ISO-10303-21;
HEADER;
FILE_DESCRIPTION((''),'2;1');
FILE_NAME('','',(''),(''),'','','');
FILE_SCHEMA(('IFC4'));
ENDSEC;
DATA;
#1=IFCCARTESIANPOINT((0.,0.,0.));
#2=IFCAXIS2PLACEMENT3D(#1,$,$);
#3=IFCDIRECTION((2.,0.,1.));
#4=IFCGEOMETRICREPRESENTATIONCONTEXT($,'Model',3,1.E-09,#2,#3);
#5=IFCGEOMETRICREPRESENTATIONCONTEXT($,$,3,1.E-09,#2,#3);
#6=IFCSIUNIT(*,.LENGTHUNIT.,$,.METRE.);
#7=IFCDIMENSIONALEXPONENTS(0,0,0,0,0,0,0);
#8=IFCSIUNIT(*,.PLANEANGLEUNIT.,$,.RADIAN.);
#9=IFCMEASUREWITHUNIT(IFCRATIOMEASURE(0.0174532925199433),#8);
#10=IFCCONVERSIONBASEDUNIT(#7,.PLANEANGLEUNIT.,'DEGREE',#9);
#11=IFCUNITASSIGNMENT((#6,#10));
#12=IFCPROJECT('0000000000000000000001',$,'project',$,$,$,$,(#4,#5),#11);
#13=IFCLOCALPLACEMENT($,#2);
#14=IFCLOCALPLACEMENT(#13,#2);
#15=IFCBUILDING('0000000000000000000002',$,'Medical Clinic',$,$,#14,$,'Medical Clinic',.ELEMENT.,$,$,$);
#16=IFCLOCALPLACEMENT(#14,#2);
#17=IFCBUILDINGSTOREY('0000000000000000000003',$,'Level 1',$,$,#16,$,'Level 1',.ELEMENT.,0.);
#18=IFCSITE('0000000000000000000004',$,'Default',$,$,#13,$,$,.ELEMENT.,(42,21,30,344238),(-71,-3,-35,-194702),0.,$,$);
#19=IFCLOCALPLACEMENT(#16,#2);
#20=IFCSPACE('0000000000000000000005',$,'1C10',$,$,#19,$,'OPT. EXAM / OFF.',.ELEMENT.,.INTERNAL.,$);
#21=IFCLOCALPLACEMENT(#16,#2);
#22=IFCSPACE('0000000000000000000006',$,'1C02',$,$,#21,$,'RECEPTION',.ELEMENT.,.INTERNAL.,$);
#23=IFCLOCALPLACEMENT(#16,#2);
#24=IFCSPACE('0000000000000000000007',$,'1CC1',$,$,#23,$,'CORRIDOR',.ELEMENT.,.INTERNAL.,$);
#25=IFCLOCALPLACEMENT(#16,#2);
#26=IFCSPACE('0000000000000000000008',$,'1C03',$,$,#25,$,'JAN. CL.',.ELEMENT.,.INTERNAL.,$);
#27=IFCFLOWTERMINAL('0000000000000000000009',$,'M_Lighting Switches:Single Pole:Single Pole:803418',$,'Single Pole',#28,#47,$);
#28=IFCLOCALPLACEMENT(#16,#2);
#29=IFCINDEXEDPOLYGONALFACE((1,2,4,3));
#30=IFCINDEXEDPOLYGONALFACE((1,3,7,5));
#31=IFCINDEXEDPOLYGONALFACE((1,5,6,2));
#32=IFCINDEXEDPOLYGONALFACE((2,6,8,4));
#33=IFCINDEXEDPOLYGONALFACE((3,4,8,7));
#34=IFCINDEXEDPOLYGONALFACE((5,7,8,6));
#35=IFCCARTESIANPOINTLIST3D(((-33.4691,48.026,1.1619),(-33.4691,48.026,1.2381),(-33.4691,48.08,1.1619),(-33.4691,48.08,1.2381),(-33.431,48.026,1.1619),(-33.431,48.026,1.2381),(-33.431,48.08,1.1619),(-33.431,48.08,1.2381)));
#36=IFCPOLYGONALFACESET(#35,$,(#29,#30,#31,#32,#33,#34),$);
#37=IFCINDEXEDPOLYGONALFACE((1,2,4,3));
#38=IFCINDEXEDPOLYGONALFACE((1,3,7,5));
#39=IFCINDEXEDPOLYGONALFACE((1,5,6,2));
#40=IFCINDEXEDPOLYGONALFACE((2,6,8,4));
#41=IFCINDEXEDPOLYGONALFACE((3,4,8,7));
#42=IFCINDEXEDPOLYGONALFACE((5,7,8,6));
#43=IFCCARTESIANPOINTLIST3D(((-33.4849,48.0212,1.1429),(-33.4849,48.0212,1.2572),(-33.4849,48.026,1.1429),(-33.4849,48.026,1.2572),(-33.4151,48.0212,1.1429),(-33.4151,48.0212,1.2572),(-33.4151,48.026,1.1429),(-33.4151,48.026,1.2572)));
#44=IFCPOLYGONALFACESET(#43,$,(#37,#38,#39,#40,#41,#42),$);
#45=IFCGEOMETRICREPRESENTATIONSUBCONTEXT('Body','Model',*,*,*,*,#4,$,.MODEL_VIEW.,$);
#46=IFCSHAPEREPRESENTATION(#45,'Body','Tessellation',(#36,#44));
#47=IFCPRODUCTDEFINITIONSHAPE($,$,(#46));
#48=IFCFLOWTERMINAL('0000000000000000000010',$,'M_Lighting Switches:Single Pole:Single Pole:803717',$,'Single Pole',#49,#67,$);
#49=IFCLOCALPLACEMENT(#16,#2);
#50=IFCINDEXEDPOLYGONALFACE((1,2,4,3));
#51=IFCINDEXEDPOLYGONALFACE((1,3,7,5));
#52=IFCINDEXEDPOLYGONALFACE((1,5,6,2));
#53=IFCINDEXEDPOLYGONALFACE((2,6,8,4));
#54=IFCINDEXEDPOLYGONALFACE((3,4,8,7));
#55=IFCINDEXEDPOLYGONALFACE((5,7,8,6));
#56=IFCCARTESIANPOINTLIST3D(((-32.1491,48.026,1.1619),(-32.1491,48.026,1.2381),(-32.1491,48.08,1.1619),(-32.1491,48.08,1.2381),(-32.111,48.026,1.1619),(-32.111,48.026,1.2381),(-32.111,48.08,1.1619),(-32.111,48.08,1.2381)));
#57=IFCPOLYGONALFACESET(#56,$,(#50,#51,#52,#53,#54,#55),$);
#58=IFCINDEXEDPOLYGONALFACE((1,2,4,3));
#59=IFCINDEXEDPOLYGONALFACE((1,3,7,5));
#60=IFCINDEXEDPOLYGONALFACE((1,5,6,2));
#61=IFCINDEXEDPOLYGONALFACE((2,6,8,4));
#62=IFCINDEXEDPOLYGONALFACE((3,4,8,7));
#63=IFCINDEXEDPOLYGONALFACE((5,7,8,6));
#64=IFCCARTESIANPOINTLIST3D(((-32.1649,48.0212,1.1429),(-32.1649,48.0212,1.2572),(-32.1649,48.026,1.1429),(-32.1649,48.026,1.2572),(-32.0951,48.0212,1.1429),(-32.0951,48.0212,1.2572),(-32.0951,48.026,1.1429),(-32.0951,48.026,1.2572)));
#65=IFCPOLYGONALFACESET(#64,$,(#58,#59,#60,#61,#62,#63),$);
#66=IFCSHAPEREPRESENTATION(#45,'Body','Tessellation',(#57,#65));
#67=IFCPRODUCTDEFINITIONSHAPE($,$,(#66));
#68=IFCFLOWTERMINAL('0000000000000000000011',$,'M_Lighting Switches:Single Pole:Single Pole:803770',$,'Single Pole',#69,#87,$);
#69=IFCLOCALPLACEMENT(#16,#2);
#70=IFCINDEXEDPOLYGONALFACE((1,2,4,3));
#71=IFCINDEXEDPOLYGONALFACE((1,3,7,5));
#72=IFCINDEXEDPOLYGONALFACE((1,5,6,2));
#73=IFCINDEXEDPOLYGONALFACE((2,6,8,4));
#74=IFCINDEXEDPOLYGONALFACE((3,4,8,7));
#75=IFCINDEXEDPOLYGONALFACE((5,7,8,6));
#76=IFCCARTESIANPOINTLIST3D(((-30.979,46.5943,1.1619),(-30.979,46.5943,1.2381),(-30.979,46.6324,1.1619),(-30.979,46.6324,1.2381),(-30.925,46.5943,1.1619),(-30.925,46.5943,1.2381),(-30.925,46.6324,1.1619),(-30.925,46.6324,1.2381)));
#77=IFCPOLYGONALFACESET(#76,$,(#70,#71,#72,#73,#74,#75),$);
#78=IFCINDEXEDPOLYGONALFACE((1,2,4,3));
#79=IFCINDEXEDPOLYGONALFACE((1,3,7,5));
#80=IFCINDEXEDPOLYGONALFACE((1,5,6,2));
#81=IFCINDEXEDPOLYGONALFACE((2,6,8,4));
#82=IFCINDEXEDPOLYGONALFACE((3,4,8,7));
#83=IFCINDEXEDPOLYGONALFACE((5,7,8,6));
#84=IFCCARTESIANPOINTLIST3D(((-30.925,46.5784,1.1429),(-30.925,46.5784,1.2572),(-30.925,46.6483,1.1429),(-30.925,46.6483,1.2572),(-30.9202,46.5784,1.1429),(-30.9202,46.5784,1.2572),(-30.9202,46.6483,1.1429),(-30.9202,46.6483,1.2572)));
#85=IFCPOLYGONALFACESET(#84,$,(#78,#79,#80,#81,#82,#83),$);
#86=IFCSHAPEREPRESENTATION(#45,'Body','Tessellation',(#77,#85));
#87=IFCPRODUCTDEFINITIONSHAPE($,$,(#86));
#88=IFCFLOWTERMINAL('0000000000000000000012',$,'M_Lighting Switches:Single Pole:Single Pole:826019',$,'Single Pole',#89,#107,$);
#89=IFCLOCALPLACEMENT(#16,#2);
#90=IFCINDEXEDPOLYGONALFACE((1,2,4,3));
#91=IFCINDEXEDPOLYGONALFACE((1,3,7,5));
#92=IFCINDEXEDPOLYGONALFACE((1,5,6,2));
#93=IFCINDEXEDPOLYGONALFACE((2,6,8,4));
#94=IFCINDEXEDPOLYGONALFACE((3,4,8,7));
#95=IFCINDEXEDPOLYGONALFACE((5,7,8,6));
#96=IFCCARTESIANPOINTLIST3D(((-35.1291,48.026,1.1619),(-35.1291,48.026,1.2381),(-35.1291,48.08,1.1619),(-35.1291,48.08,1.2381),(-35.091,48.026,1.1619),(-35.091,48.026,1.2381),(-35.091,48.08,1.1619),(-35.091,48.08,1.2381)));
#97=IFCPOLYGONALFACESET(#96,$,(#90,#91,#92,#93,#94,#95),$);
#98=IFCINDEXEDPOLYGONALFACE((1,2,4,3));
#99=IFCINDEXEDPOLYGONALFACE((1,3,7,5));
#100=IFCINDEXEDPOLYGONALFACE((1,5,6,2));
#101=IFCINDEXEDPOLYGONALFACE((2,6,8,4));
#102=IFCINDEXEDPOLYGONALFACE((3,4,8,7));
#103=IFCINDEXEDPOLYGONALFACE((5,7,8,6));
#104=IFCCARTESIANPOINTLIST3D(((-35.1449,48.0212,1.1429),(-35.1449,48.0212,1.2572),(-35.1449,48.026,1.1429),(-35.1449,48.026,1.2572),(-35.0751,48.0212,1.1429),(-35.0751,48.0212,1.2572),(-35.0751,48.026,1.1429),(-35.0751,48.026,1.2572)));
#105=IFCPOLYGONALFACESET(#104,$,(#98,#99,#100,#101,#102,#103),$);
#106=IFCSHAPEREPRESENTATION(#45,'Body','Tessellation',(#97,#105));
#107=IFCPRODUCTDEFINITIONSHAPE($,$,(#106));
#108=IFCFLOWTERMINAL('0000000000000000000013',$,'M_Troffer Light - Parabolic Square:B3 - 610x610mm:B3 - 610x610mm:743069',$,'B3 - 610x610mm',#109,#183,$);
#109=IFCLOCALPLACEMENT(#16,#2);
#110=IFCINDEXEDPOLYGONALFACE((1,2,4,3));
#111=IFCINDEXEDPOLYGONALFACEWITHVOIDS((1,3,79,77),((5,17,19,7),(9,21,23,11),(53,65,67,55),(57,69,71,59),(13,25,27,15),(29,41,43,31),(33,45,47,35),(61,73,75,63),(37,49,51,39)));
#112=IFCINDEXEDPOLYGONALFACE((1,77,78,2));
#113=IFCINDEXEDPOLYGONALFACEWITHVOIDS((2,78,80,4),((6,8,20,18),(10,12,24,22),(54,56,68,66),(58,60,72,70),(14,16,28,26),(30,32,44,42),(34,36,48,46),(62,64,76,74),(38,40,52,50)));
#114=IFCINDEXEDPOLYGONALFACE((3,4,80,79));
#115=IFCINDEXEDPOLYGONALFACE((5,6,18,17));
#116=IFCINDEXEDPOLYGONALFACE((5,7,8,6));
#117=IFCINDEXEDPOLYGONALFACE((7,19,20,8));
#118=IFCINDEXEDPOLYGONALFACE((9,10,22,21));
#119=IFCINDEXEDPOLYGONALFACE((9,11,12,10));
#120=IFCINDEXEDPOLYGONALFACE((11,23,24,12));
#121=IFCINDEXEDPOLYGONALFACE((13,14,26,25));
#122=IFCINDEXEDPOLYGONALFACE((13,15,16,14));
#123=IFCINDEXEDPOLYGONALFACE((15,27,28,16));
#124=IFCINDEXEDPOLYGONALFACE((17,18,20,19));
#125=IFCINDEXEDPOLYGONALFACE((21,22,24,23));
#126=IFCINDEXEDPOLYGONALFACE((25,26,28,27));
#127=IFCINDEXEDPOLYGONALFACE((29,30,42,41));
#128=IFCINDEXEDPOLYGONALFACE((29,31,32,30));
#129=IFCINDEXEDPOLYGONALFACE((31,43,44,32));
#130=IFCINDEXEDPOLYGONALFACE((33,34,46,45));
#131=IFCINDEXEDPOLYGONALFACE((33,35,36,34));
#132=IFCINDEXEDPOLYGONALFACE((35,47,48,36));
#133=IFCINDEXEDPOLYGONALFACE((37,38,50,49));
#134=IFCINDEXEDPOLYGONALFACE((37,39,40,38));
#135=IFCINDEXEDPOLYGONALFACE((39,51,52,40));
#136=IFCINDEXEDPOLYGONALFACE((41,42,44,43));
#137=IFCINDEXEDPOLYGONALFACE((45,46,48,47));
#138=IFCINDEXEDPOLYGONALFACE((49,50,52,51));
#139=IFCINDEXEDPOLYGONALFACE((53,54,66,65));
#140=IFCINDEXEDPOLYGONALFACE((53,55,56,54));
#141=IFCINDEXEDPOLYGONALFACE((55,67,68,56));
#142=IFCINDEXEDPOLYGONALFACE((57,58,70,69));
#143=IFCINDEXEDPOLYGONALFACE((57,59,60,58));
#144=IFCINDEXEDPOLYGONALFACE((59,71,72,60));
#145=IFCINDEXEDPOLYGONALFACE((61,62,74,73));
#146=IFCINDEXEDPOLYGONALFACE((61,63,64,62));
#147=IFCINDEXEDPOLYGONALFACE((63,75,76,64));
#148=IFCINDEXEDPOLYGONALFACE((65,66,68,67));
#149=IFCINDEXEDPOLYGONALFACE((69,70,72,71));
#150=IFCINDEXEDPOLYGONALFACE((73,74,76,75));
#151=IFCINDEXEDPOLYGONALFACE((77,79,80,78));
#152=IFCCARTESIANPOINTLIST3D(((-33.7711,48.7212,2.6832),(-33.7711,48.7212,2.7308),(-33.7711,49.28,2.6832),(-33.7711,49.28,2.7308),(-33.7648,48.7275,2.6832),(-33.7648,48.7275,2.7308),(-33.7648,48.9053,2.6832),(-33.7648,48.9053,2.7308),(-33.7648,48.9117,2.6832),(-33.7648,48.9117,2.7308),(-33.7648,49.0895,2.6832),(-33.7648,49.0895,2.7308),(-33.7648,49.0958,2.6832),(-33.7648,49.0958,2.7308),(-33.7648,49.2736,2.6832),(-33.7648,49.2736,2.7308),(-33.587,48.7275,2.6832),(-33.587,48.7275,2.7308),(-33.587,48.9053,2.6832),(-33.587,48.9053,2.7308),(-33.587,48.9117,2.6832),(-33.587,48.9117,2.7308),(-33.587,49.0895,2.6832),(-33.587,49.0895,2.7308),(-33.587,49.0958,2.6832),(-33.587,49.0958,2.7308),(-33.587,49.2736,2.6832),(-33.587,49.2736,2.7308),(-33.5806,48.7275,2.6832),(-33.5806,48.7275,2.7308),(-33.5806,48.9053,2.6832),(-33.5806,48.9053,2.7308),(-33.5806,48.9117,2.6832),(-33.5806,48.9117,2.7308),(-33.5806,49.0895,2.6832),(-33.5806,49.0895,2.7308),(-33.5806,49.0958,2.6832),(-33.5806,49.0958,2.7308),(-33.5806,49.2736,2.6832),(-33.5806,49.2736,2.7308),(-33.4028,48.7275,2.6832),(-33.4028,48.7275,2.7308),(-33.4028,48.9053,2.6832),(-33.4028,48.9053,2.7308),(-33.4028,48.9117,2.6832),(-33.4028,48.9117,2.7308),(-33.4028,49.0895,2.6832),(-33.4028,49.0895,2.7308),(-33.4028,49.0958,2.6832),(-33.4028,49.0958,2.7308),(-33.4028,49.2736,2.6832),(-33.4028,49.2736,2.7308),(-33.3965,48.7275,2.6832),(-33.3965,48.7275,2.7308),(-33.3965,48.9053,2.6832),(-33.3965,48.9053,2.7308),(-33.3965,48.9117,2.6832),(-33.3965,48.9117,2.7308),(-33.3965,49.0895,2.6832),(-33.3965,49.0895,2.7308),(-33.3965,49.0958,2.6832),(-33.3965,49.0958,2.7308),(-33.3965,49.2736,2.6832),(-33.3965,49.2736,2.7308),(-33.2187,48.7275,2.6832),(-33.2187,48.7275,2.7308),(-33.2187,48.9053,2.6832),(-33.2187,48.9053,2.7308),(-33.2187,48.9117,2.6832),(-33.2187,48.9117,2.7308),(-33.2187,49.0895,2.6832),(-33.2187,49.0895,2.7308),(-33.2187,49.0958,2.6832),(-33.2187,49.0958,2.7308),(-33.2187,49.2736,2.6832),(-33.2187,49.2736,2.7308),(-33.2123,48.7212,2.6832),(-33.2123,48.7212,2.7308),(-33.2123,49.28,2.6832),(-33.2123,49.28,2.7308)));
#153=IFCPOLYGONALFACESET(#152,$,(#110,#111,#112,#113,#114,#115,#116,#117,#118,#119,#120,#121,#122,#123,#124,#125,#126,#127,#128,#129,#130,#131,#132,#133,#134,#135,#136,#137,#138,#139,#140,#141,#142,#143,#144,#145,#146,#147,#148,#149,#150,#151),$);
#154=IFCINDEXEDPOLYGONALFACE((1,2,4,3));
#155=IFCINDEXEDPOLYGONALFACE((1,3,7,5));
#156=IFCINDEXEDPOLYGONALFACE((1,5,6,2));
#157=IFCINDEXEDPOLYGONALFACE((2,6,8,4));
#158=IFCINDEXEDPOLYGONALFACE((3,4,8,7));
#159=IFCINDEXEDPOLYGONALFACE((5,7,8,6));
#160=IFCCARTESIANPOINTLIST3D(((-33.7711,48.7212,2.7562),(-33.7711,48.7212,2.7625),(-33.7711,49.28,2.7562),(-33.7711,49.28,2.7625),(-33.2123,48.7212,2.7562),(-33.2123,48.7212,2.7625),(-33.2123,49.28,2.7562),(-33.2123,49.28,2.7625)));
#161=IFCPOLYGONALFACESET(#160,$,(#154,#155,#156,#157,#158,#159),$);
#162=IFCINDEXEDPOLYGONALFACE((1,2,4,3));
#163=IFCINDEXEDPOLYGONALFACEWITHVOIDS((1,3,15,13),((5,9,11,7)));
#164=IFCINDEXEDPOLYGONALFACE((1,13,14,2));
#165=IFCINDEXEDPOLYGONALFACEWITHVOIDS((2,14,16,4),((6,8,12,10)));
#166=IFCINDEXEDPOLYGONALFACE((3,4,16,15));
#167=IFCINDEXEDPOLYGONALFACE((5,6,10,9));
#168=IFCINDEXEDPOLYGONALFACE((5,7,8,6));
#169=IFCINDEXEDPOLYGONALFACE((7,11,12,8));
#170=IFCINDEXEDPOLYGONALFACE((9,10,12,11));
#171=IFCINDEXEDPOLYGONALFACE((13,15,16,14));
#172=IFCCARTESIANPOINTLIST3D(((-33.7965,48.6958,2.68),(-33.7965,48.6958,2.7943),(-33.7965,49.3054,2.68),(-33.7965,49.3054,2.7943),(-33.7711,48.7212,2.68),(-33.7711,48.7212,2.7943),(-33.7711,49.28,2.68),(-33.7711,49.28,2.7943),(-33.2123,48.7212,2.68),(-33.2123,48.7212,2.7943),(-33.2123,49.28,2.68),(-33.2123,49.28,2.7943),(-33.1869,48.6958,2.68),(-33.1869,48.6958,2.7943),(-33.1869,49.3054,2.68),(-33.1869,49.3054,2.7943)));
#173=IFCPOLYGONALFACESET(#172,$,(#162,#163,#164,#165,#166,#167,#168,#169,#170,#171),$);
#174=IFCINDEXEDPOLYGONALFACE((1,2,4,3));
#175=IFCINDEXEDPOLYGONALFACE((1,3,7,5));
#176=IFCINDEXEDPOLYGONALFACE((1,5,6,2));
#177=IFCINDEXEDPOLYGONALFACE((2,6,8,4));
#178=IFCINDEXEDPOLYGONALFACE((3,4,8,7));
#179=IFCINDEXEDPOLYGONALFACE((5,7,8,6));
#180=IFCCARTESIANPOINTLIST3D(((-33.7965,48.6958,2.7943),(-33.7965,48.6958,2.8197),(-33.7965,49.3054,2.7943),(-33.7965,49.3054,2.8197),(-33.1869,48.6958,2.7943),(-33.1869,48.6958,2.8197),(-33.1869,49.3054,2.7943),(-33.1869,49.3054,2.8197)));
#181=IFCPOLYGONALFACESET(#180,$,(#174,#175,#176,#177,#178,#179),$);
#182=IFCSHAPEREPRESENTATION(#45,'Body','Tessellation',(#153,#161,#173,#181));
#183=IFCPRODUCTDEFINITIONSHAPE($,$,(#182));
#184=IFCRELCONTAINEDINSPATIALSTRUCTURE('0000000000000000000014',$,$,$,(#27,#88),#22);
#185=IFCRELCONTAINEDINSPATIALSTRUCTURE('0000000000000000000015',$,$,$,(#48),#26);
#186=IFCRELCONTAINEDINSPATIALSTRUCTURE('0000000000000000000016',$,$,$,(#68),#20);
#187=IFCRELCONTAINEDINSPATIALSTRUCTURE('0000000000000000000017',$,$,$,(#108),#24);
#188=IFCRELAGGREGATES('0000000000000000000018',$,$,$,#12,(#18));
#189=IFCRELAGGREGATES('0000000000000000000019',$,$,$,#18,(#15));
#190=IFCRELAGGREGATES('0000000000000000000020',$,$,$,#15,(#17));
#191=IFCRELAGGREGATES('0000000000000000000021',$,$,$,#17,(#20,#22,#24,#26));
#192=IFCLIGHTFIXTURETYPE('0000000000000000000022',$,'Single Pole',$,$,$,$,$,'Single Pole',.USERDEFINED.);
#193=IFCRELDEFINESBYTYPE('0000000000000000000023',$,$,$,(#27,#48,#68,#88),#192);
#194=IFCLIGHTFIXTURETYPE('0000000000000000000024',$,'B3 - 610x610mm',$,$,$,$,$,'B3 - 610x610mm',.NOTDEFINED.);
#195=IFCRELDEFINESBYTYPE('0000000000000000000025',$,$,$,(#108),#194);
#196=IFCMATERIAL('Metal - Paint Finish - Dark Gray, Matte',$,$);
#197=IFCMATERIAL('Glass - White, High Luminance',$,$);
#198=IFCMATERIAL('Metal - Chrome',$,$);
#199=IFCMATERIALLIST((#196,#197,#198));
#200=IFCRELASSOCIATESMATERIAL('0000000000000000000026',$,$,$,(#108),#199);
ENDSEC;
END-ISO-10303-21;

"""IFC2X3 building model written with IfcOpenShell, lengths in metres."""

from ifc_helpers import new_model, entity, si_unit, converted_unit, direction, frame, frame_2d, origin, origin_2d_with_axis, place, context, subcontext, project, spatial, polyline, rectangle, outline, extrude, source, transform, mapped, material, material_list, type_object, type_shapes, element, save


model = new_model("IFC2X3")

# Units and contexts
model_context = context("Model", 3, precision=1e-09, world=origin(), true_north=direction((2.0, 0.0, 1.0)))
context_of_model = context(None, 3, precision=1e-09, world=origin(), true_north=direction((2.0, 0.0, 1.0)))
body_context = subcontext(model_context, "Body", "Model", "MODEL_VIEW")
ifc_project = project(units=[si_unit("LENGTHUNIT", "METRE"), converted_unit("PLANEANGLEUNIT", "DEGREE", entity("IfcRatioMeasure", 0.0174532925199433), si_unit("PLANEANGLEUNIT", "RADIAN"), dimensions=[0, 0, 0, 0, 0, 0, 0])], contexts=[model_context, context_of_model])

# Site, building, storey, space
site_placement = place(None, origin())
site = spatial("IfcSite", under=ifc_project, at=site_placement, Name="Default", CompositionType="ELEMENT", RefLatitude=(42, 21, 30, 344238), RefLongitude=(-71, -3, -35, -194702), RefElevation=0.0)
building_placement = place(site_placement, origin())
building = spatial("IfcBuilding", under=site, at=building_placement, Name="Medical Clinic", LongName="Medical Clinic", CompositionType="ELEMENT")
storey_placement = place(building_placement, origin())
storey = spatial("IfcBuildingStorey", under=building, at=storey_placement, Name="Level 1", LongName="Level 1", CompositionType="ELEMENT", Elevation=0.0)
space_1_placement = place(storey_placement, origin())
space_1 = spatial("IfcSpace", under=storey, at=space_1_placement, Name="1C10", LongName="OPT. EXAM / OFF.", CompositionType="ELEMENT", InteriorOrExteriorSpace="INTERNAL")

# Shared definitions
space_2_placement = place(storey_placement, origin())
space_2 = spatial("IfcSpace", under=storey, at=space_2_placement, Name="1C02", LongName="RECEPTION", CompositionType="ELEMENT", InteriorOrExteriorSpace="INTERNAL")

# Shared definitions
space_3_placement = place(storey_placement, origin())
space_3 = spatial("IfcSpace", under=storey, at=space_3_placement, Name="1CC1", LongName="CORRIDOR", CompositionType="ELEMENT", InteriorOrExteriorSpace="INTERNAL")

# Flow terminal
light_fixture_type_1 = type_object("IfcLightFixtureType", Name="Single Pole", ElementType="Single Pole", PredefinedType="USERDEFINED")
shared_shape_1 = source(origin(), body_context, "Body", "SweptSolid", [
    extrude(rectangle(XDim=0.0381, YDim=0.0762, at=origin_2d_with_axis()), frame((0.0, 0.0, -0.054), z_axis=(0.0, 0.0, 1.0), x_axis=(-1.0, 0.0, 0.0)), (0.0, 0.0, 1.0), 0.054),
    extrude(rectangle(XDim=0.0698, YDim=0.1143, at=frame_2d((0.0, 0.0), x_axis=(1.0, 0.0))), frame((0.0, 0.0, 0.0), z_axis=(0.0, 0.0, 1.0), x_axis=(-1.0, 0.0, 0.0)), (0.0, 0.0, 1.0), 0.0048),
])
type_shapes(light_fixture_type_1, [shared_shape_1])
flow_terminal_1_placement = place(space_2_placement, frame((-33.45, 48.026, 1.2), z_axis=(0.0, -1.0, 0.0), x_axis=(1.0, 0.0, 0.0)))
element("IfcFlowTerminal", 1, at=flow_terminal_1_placement, inside=space_2, type_object=light_fixture_type_1, Name="M_Lighting Switches:Single Pole:Single Pole:803418", ObjectType="Single Pole", context=body_context, shape_type="MappedRepresentation", body=[
    mapped(shared_shape_1, transform((0.0, 0.0, 0.0), scale=1.0)),
])

# Shared definitions
space_4_placement = place(storey_placement, origin())
space_4 = spatial("IfcSpace", under=storey, at=space_4_placement, Name="1C03", LongName="JAN. CL.", CompositionType="ELEMENT", InteriorOrExteriorSpace="INTERNAL")

# Flow terminals
flow_terminal_2_placement = place(space_4_placement, frame((-32.13, 48.026, 1.2), z_axis=(0.0, -1.0, 0.0), x_axis=(1.0, 0.0, 0.0)))
element("IfcFlowTerminal", 2, at=flow_terminal_2_placement, inside=space_4, type_object=light_fixture_type_1, Name="M_Lighting Switches:Single Pole:Single Pole:803717", ObjectType="Single Pole", context=body_context, shape_type="MappedRepresentation", body=[
    mapped(shared_shape_1, transform((0.0, 0.0, 0.0), scale=1.0)),
])
flow_terminal_3_placement = place(space_1_placement, frame((-30.925, 46.6133, 1.2), z_axis=(1.0, 0.0, 0.0), x_axis=(0.0, 1.0, 0.0)))
element("IfcFlowTerminal", 3, at=flow_terminal_3_placement, inside=space_1, type_object=light_fixture_type_1, Name="M_Lighting Switches:Single Pole:Single Pole:803770", ObjectType="Single Pole", context=body_context, shape_type="MappedRepresentation", body=[
    mapped(shared_shape_1, transform((0.0, 0.0, 0.0), scale=1.0)),
])
flow_terminal_4_placement = place(space_2_placement, frame((-35.11, 48.026, 1.2), z_axis=(0.0, -1.0, 0.0), x_axis=(1.0, 0.0, 0.0)))
element("IfcFlowTerminal", 4, at=flow_terminal_4_placement, inside=space_2, type_object=light_fixture_type_1, Name="M_Lighting Switches:Single Pole:Single Pole:826019", ObjectType="Single Pole", context=body_context, shape_type="MappedRepresentation", body=[
    mapped(shared_shape_1, transform((0.0, 0.0, 0.0), scale=1.0)),
])
ifc_material_1 = material(Name="Metal - Paint Finish - Dark Gray, Matte")
ifc_material_2 = material(Name="Glass - White, High Luminance")
ifc_material_3 = material(Name="Metal - Chrome")
ifc_material_list_1 = material_list([ifc_material_1, ifc_material_2, ifc_material_3])
light_fixture_type_2 = type_object("IfcLightFixtureType", Name="B3 - 610x610mm", ElementType="B3 - 610x610mm", PredefinedType="NOTDEFINED")
shared_shape_2 = source(origin(), body_context, "Body", "SweptSolid", [
    extrude(outline(polyline([(-0.2794, -0.2794), (0.2794, -0.2794), (0.2794, 0.2794), (-0.2794, 0.2794), (-0.2794, -0.2794)]), holes=[polyline([(-0.0952, 0.0953), (-0.273, 0.0953), (-0.273, 0.2731), (-0.0952, 0.2731), (-0.0952, 0.0953)]), polyline([(0.2731, 0.0953), (0.0953, 0.0953), (0.0953, 0.2731), (0.2731, 0.2731), (0.2731, 0.0953)]), polyline([(-0.0889, 0.2731), (0.0889, 0.2731), (0.0889, 0.0953), (-0.0889, 0.0953), (-0.0889, 0.2731)]), polyline([(0.2731, -0.273), (0.0953, -0.273), (0.0953, -0.0952), (0.2731, -0.0952), (0.2731, -0.273)]), polyline([(0.0889, -0.273), (-0.0889, -0.273), (-0.0889, -0.0952), (0.0889, -0.0952), (0.0889, -0.273)]), polyline([(-0.0952, -0.273), (-0.273, -0.273), (-0.273, -0.0952), (-0.0952, -0.0952), (-0.0952, -0.273)]), polyline([(-0.0952, -0.0889), (-0.273, -0.0889), (-0.273, 0.0889), (-0.0952, 0.0889), (-0.0952, -0.0889)]), polyline([(0.0889, -0.0889), (-0.0889, -0.0889), (-0.0889, 0.0889), (0.0889, 0.0889), (0.0889, -0.0889)]), polyline([(0.2731, -0.0889), (0.0953, -0.0889), (0.0953, 0.0889), (0.2731, 0.0889), (0.2731, -0.0889)])]), frame((0.0, -0.3048, -0.0508), z_axis=(0.0, 0.0, 1.0), x_axis=(-1.0, 0.0, 0.0)), (0.0, 0.0, 1.0), 0.0476),
    extrude(rectangle(XDim=0.5588, YDim=0.5588, at=origin_2d_with_axis()), frame((0.0, -0.3048, -0.0825), z_axis=(0.0, 0.0, 1.0), x_axis=(-1.0, 0.0, 0.0)), (0.0, 0.0, 1.0), 0.0064),
    extrude(outline(polyline([(-0.3048, -0.3048), (0.3048, -0.3048), (0.3048, 0.3048), (-0.3048, 0.3048), (-0.3048, -0.3048)]), holes=[polyline([(0.2794, 0.2794), (0.2794, -0.2794), (-0.2794, -0.2794), (-0.2794, 0.2794), (0.2794, 0.2794)])]), frame((0.0, -0.3048, -0.1143)), (0.0, 0.0, 1.0), 0.1143),
    extrude(rectangle(XDim=0.6096, YDim=0.6096, at=origin_2d_with_axis()), frame((0.0, -0.3048, -0.1397), z_axis=(0.0, 0.0, 1.0), x_axis=(-1.0, 0.0, 0.0)), (0.0, 0.0, 1.0), 0.0254),
])
type_shapes(light_fixture_type_2, [shared_shape_2])
for number, where, z_axis, x_axis, name in (
    (5, (-33.4917, 48.6958, 2.68), (0.0, 0.0, -1.0), (1.0, 0.0, 0.0), "M_Troffer Light - Parabolic Square:B3 - 610x610mm:B3 - 610x610mm:743069"),
):
    element("IfcFlowTerminal", number, at=place(space_3_placement, frame(where, z_axis=z_axis, x_axis=x_axis)), inside=space_3, type_object=light_fixture_type_2, material=ifc_material_list_1, Name=name, ObjectType="B3 - 610x610mm", context=body_context, shape_type="MappedRepresentation", body=[
        mapped(shared_shape_2, transform((0.0, 0.0, 0.0), scale=1.0)),
    ])

save(model, "model.ifc")
